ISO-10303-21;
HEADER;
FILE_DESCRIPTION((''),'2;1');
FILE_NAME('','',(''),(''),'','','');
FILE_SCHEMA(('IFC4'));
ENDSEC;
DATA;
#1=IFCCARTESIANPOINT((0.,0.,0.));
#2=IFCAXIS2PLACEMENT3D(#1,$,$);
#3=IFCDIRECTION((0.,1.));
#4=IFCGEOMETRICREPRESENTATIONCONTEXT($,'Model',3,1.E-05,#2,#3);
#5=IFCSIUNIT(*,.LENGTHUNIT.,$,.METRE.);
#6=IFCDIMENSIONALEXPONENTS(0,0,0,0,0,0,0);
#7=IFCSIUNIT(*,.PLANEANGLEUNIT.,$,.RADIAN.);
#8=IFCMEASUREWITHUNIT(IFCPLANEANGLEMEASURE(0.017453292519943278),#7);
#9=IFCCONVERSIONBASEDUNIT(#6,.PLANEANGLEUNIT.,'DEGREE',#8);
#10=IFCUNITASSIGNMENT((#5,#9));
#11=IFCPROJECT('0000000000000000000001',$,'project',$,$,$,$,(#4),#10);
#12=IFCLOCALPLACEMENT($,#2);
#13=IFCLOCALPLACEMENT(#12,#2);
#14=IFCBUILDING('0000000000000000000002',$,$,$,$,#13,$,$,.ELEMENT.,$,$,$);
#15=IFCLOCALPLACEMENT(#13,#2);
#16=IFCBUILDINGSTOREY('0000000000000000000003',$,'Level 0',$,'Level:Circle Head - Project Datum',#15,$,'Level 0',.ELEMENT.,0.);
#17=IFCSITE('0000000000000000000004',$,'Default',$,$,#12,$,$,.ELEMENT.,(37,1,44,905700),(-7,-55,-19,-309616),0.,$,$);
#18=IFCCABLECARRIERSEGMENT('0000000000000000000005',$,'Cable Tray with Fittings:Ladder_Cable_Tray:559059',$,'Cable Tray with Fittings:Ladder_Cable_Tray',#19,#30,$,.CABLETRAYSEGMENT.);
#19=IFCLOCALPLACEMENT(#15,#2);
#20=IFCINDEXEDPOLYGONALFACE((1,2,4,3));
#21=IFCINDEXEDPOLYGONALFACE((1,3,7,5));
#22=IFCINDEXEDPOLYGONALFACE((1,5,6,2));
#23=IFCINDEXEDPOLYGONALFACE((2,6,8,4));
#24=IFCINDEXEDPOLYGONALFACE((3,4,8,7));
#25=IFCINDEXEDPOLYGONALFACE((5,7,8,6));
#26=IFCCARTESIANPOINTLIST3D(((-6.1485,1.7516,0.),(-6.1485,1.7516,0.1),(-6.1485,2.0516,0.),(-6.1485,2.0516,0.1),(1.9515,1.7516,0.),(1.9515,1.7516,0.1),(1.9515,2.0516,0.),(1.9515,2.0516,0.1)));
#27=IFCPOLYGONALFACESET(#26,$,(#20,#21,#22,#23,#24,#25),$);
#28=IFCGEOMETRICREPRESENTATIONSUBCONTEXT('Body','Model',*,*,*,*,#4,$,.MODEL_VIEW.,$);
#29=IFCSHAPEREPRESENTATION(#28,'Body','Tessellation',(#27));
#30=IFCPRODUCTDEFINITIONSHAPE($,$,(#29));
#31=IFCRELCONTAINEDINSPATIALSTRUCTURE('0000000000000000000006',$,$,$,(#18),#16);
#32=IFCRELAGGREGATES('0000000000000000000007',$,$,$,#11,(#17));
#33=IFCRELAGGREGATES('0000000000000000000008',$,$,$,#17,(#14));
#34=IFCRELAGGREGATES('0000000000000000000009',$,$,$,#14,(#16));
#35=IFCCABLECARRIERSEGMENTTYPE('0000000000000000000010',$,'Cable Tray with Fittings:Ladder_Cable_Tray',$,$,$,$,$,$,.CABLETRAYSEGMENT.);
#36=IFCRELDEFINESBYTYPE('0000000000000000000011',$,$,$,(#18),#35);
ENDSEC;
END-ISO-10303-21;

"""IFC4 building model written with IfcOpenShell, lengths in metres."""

from ifc_helpers import new_model, entity, si_unit, converted_unit, direction, frame, origin, place, context, subcontext, project, spatial, indexed_curve, outline, extrude, type_object, element, save


model = new_model("IFC4")

# Units and contexts
model_context = context("Model", 3, precision=1e-05, world=origin(), true_north=direction((0.0, 1.0)))
body_context = subcontext(model_context, "Body", "Model", "MODEL_VIEW")
ifc_project = project(units=[si_unit("LENGTHUNIT", "METRE"), converted_unit("PLANEANGLEUNIT", "DEGREE", entity("IfcPlaneAngleMeasure", 0.017453292519943278), si_unit("PLANEANGLEUNIT", "RADIAN"), dimensions=[0, 0, 0, 0, 0, 0, 0])], contexts=[model_context])

# Site, building, storey
site_placement = place(None, origin())
site = spatial("IfcSite", under=ifc_project, at=site_placement, Name="Default", CompositionType="ELEMENT", RefLatitude=(37, 1, 44, 905700), RefLongitude=(-7, -55, -19, -309616), RefElevation=0.0)
building_placement = place(site_placement, origin())
building = spatial("IfcBuilding", under=site, at=building_placement, CompositionType="ELEMENT")
storey_placement = place(building_placement, origin())
storey = spatial("IfcBuildingStorey", under=building, at=storey_placement, Name="Level 0", ObjectType="Level:Circle Head - Project Datum", LongName="Level 0", CompositionType="ELEMENT", Elevation=0.0)

# Cable carrier segment
cable_carrier_segment_type = type_object("IfcCableCarrierSegmentType", Name="Cable Tray with Fittings:Ladder_Cable_Tray", PredefinedType="CABLETRAYSEGMENT")
cable_carrier_segment_placement = place(storey_placement, origin())
element("IfcCableCarrierSegment", 1, at=cable_carrier_segment_placement, inside=storey, type_object=cable_carrier_segment_type, Name="Cable Tray with Fittings:Ladder_Cable_Tray:559059", ObjectType="Cable Tray with Fittings:Ladder_Cable_Tray", PredefinedType="CABLETRAYSEGMENT", context=body_context, shape_type="SweptSolid", body=[
    extrude(outline(indexed_curve([(-4.05, -0.15), (4.05, -0.15), (4.05, 0.15), (-4.05, 0.15), (-4.05, -0.15)], self_intersect=False)), frame((-2.0985, 1.9016, 0.0)), (0.0, 0.0, 1.0), 0.1),
])

save(model, "model.ifc")
